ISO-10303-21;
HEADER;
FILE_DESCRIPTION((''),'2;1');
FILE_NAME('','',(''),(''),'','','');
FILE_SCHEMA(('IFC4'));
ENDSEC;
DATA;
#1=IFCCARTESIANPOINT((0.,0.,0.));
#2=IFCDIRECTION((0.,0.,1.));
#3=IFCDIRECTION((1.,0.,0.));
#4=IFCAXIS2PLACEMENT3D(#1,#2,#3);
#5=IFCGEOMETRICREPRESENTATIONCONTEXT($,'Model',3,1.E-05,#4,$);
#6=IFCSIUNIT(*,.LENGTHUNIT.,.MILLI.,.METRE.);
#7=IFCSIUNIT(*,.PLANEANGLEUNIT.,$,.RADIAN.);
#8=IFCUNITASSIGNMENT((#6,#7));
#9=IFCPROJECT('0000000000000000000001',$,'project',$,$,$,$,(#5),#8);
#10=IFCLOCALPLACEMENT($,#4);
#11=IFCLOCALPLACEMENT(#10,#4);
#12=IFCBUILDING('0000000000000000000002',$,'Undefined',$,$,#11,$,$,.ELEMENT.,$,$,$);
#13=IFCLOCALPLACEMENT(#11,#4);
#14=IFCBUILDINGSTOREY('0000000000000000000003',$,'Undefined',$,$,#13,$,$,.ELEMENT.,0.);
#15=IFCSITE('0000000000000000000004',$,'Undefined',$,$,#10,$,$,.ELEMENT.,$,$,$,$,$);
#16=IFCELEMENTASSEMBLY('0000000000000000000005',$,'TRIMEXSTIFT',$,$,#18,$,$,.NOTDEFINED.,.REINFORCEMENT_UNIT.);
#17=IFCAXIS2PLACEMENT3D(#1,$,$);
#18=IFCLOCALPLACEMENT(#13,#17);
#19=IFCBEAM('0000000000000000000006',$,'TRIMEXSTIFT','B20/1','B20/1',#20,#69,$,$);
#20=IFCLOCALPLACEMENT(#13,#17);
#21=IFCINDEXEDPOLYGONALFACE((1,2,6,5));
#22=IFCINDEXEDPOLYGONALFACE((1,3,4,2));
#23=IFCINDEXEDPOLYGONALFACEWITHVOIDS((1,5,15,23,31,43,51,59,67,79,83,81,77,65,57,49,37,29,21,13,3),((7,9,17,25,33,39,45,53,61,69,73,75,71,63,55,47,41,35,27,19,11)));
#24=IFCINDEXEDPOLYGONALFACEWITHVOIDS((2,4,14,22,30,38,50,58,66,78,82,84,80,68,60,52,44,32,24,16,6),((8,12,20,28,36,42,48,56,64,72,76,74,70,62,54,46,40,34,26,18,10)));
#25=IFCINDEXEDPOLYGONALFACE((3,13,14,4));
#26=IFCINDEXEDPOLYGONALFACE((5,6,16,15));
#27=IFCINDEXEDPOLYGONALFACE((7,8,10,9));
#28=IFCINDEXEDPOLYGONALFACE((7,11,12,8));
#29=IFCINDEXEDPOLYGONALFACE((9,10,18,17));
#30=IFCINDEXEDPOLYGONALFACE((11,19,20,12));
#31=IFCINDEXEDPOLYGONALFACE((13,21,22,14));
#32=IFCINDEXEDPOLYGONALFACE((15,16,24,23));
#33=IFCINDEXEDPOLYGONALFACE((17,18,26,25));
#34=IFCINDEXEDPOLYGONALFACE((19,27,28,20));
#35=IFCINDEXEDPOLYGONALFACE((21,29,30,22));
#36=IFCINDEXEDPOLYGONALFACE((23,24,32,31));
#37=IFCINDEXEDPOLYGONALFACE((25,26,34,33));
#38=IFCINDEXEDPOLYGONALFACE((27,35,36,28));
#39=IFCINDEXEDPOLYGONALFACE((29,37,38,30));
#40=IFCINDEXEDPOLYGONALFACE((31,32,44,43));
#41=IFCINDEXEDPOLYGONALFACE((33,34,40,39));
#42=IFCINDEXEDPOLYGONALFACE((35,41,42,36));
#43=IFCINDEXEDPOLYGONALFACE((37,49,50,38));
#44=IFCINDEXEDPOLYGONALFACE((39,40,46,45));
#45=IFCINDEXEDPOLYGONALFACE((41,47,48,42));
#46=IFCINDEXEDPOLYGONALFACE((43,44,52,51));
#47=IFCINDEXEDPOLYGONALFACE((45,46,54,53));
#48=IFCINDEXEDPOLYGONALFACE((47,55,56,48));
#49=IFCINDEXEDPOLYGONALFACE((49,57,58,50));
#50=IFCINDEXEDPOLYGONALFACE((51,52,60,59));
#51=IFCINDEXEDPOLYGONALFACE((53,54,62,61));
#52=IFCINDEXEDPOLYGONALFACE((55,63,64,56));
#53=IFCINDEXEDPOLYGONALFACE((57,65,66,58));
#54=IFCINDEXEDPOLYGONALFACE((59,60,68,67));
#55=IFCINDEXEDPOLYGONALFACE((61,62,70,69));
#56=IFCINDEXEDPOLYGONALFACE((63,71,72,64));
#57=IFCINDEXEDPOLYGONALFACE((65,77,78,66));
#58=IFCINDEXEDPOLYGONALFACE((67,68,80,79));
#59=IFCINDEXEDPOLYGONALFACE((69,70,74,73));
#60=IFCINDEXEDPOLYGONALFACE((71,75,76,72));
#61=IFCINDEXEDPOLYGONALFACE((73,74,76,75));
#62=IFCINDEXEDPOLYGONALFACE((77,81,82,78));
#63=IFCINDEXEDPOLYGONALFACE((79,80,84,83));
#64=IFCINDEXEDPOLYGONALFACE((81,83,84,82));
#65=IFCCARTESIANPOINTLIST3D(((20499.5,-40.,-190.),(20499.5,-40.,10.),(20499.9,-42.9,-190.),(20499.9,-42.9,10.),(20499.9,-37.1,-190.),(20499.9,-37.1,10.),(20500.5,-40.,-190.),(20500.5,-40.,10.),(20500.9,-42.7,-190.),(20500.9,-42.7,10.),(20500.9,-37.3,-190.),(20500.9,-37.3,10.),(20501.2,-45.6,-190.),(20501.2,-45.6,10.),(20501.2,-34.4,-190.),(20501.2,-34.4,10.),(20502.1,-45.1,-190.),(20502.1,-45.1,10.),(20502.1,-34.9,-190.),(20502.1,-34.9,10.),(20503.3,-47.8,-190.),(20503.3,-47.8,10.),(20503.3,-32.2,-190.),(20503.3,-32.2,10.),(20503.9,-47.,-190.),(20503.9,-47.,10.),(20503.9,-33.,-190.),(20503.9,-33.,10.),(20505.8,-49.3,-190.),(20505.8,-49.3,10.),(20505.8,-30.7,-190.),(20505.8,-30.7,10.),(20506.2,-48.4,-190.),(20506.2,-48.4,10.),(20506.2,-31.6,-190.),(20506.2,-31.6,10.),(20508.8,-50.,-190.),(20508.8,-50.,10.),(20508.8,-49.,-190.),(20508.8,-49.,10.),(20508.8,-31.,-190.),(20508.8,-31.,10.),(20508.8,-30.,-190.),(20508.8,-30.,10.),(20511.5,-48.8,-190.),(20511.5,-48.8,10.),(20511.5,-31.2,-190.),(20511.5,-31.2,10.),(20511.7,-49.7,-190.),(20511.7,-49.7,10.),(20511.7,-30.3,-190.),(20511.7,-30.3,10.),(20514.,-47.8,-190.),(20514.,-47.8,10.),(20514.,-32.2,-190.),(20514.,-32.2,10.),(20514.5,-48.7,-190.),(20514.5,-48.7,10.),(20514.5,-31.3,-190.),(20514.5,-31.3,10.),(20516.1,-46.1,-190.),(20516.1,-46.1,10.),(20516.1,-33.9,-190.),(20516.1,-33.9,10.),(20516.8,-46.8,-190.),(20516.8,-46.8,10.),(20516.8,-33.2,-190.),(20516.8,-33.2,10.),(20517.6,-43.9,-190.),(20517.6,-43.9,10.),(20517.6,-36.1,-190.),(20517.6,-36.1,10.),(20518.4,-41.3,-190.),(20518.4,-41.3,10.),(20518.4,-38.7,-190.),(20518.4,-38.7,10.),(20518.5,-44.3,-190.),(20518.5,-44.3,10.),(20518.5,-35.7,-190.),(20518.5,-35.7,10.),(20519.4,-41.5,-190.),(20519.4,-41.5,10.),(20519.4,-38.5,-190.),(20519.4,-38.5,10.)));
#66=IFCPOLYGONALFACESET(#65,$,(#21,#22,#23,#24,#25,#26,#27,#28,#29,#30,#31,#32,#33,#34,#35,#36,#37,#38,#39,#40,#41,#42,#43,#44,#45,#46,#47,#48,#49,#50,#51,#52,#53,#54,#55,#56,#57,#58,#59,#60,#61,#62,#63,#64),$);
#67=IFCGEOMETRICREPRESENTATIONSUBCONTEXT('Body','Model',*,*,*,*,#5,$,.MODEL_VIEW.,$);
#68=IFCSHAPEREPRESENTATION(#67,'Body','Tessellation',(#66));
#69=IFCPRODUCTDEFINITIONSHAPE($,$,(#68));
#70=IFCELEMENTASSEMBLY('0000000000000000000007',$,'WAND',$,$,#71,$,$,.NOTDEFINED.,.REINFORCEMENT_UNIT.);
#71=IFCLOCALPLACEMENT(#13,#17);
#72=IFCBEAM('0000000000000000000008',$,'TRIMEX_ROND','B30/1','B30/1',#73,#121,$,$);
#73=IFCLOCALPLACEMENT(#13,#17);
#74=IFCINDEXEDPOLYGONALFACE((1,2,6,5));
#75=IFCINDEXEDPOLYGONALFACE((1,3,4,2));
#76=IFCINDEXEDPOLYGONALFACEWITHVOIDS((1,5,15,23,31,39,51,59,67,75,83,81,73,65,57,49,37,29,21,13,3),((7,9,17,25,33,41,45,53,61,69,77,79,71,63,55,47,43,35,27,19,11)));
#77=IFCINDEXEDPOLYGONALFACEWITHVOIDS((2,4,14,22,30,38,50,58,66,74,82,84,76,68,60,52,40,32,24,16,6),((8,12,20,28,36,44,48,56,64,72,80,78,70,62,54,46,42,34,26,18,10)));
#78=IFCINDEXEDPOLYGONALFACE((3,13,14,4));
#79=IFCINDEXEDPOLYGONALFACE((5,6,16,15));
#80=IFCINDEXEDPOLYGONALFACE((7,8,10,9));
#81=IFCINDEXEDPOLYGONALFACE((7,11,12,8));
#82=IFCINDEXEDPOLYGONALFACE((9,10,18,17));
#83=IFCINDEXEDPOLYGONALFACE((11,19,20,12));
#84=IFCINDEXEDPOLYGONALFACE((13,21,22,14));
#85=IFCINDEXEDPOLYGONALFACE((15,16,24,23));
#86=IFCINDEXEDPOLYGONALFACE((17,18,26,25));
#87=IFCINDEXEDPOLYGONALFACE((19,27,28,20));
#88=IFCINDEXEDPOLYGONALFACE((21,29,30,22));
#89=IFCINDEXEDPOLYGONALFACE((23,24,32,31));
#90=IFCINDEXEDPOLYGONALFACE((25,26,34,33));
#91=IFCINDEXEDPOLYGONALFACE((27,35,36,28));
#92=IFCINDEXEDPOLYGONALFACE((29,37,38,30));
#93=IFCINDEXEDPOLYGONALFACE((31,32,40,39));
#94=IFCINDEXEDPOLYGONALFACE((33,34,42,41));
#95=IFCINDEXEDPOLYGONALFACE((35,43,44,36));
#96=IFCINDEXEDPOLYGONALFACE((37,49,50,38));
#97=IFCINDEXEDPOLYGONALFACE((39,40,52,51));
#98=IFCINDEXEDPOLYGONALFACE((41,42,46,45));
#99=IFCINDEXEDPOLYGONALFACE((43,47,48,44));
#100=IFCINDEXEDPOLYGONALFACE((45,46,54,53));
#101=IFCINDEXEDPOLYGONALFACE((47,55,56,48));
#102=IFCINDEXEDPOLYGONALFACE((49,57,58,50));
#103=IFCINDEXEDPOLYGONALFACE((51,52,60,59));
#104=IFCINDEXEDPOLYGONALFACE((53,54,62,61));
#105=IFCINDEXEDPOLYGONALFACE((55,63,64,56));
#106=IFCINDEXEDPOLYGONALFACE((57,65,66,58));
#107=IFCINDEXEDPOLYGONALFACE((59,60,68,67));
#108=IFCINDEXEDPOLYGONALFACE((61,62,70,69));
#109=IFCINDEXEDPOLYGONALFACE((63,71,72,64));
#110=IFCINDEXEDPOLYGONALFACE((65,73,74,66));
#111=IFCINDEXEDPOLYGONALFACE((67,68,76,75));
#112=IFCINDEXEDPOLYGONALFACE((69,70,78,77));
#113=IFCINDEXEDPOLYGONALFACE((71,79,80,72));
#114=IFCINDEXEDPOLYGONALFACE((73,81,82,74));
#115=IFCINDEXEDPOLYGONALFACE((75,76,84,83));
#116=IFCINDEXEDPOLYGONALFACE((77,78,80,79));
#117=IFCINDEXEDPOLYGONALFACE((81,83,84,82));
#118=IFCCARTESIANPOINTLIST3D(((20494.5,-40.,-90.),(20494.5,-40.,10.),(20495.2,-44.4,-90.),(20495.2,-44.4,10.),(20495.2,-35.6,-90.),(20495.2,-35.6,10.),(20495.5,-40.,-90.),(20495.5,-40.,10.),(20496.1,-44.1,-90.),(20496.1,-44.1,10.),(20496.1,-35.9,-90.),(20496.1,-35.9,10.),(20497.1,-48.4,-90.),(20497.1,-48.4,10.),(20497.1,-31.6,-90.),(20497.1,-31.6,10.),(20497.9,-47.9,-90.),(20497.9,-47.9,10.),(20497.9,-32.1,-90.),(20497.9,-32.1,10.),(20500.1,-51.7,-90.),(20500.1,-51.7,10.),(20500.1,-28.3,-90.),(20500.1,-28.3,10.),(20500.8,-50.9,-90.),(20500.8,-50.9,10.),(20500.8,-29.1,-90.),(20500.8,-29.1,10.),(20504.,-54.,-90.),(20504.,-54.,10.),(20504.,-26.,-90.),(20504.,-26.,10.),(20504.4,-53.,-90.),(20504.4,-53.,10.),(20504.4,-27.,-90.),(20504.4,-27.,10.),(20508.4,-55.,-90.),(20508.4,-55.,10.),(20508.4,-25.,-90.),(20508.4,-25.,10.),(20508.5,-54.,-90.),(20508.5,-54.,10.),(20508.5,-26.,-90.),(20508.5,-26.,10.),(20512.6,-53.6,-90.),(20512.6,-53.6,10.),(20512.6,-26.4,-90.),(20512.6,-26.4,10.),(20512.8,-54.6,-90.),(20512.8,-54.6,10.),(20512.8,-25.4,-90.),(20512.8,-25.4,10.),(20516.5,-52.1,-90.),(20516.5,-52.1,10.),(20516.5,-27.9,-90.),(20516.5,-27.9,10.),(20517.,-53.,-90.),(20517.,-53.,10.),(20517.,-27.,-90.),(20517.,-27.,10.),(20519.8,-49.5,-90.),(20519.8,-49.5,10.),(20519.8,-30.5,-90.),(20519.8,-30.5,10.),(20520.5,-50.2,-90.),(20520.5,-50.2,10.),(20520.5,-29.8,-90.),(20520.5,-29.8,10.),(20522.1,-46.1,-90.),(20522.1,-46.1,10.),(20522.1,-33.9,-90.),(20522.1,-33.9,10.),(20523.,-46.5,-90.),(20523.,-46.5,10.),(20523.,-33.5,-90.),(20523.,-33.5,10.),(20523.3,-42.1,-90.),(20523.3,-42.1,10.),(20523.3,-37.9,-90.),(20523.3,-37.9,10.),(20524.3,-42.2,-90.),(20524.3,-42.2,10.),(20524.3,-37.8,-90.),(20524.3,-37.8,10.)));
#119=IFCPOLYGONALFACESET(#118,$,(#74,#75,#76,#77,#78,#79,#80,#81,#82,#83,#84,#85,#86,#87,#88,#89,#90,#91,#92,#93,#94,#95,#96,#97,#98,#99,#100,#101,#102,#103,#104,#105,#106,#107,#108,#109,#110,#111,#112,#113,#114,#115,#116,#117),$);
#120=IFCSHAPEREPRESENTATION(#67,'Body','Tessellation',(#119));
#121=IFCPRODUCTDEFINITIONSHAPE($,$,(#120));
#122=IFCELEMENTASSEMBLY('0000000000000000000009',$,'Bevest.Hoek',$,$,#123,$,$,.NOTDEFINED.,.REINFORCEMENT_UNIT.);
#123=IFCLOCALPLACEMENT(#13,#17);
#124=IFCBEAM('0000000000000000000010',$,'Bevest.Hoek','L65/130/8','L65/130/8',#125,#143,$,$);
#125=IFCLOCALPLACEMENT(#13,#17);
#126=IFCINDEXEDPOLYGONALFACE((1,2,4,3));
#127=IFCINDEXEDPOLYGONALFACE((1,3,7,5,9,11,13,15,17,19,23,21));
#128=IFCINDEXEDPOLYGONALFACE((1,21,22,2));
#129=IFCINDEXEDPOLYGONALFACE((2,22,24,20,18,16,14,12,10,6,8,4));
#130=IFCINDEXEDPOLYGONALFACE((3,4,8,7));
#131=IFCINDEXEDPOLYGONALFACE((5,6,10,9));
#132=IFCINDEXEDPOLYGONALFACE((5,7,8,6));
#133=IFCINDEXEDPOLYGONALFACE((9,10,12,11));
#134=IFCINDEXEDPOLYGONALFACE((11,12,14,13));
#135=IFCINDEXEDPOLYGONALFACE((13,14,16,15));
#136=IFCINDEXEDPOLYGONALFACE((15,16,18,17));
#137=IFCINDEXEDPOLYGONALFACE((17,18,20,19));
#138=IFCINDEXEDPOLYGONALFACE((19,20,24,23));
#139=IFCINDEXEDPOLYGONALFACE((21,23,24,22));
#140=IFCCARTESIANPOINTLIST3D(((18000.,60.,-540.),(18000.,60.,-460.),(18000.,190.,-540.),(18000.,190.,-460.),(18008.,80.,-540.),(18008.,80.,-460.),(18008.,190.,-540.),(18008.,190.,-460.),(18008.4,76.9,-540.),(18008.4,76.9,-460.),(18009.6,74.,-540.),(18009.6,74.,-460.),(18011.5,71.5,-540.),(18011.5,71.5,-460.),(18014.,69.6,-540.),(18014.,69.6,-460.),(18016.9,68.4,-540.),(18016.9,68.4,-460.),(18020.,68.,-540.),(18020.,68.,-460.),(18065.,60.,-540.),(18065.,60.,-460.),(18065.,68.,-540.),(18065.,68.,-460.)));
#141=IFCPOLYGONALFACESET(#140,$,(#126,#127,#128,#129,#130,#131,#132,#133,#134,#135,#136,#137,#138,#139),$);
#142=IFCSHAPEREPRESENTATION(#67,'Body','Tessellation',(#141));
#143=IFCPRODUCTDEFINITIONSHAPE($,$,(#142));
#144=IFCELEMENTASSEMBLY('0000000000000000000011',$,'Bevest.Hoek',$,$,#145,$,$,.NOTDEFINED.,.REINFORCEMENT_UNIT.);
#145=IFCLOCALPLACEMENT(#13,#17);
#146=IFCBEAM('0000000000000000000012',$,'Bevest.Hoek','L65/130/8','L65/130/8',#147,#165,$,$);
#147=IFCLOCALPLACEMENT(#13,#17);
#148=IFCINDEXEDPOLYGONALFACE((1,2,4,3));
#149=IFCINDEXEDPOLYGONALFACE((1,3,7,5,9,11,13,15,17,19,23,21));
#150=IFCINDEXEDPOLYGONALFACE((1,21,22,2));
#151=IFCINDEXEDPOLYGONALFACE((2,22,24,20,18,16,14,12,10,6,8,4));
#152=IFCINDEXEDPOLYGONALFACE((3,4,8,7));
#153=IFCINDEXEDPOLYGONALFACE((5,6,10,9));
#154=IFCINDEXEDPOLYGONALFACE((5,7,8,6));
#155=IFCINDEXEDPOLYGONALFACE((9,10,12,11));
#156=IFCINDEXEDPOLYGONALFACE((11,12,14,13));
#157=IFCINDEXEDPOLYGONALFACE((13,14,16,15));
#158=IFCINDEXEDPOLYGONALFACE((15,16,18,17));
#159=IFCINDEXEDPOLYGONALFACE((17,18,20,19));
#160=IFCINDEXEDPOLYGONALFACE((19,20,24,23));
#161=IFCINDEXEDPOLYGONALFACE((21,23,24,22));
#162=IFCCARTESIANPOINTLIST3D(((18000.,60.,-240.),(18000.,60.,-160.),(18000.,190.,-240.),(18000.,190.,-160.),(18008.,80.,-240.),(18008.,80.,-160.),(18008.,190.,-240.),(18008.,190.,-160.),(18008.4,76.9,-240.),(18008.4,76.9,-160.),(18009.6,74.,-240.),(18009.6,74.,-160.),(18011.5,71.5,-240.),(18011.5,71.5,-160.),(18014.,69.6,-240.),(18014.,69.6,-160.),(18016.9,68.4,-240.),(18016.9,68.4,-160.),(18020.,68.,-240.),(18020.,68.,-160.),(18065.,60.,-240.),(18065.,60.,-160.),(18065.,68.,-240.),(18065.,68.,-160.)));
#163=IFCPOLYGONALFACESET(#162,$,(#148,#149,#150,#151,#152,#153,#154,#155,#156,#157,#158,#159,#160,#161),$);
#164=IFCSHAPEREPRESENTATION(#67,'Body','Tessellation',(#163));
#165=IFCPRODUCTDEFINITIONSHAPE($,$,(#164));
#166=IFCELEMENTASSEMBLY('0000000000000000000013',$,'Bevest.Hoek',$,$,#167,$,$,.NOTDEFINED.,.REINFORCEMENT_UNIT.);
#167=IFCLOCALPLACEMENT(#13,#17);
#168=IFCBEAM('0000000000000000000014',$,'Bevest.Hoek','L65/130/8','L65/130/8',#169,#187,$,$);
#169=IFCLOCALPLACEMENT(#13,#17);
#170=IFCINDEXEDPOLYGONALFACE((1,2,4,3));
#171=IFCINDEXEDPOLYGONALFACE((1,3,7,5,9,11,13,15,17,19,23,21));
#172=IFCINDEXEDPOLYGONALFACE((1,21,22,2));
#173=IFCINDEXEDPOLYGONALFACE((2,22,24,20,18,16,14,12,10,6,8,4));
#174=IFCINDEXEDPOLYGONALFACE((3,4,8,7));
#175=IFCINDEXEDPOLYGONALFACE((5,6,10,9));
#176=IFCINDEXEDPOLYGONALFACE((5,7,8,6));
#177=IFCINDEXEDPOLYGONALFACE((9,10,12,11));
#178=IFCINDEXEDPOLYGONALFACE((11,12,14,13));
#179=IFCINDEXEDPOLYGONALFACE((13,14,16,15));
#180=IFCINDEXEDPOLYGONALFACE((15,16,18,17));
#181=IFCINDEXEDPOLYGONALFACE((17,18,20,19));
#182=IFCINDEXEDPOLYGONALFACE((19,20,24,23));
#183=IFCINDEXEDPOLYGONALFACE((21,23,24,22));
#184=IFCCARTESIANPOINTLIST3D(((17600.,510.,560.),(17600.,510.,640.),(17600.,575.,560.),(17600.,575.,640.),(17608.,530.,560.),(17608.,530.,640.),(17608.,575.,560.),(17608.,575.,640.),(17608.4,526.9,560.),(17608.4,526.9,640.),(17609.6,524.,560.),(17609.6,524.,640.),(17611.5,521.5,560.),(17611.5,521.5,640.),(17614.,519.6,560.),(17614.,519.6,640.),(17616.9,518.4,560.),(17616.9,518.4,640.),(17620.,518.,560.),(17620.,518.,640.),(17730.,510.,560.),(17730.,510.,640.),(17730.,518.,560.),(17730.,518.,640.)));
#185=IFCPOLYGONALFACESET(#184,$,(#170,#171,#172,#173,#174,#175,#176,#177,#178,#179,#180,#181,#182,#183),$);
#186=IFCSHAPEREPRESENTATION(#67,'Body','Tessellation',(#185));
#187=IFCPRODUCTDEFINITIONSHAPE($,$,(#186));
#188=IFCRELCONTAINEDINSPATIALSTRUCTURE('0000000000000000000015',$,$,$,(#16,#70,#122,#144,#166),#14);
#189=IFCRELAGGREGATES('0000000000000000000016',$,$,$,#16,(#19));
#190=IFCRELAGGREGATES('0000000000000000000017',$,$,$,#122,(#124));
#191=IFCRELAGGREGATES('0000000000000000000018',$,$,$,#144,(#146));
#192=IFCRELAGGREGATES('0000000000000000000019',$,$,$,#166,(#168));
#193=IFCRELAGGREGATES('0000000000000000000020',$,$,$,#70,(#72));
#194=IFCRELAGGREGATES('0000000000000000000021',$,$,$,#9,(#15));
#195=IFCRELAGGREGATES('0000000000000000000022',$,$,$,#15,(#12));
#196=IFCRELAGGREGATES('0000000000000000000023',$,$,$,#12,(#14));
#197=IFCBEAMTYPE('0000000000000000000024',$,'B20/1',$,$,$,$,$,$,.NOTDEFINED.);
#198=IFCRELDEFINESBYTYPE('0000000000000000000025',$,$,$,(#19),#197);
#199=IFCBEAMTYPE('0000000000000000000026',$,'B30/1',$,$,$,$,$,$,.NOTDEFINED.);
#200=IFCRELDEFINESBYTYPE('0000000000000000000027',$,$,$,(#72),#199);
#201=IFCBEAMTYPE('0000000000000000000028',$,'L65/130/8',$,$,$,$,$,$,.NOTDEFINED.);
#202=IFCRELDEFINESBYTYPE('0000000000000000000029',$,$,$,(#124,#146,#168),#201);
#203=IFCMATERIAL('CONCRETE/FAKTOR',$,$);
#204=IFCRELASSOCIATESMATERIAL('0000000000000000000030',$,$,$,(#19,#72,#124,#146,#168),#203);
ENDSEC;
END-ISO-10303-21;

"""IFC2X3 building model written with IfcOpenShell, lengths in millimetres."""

from ifc_helpers import new_model, si_unit, frame, frame_2d, origin_with_axes, place, context, subcontext, project, spatial, hollow_circle, l_section, extrude, material, type_object, element, aggregate, save


model = new_model("IFC2X3")

# Units and contexts
model_context = context("Model", 3, precision=1e-05, world=origin_with_axes())
body_context = subcontext(model_context, "Body", "Model", "MODEL_VIEW")
ifc_project = project(units=[si_unit("LENGTHUNIT", "METRE", prefix="MILLI"), si_unit("PLANEANGLEUNIT", "RADIAN")], contexts=[model_context])

# Site, building, storey
site_placement = place(None, origin_with_axes())
site = spatial("IfcSite", under=ifc_project, at=site_placement, Name="Undefined", CompositionType="ELEMENT")
building_placement = place(site_placement, origin_with_axes())
building = spatial("IfcBuilding", under=site, at=building_placement, Name="Undefined", CompositionType="ELEMENT")
storey_placement = place(building_placement, origin_with_axes())
storey = spatial("IfcBuildingStorey", under=building, at=storey_placement, Name="Undefined", CompositionType="ELEMENT", Elevation=0.0)

# Element assemblies, beams
assembly_1_placement = place(storey_placement, origin_with_axes())
assembly_1 = element("IfcElementAssembly", 1, at=assembly_1_placement, inside=storey, Name="TRIMEXSTIFT", AssemblyPlace="NOTDEFINED", PredefinedType="REINFORCEMENT_UNIT")
ifc_material_1 = material(Name="CONCRETE/FAKTOR")
beam_type_1 = type_object("IfcBeamType", Name="B20/1", PredefinedType="NOTDEFINED")
beam_1_placement = place(assembly_1_placement, frame((20509.5, -40.0, -190.0), z_axis=(0.0, 1.0, 0.0), x_axis=(0.0, 0.0, 1.0)))
beam_1 = element("IfcBeam", 2, at=beam_1_placement, type_object=beam_type_1, material=ifc_material_1, Name="TRIMEXSTIFT", Description="B20/1", ObjectType="B20/1", context=body_context, shape_type="SweptSolid", body=[
    extrude(hollow_circle(Radius=10.0, WallThickness=1.0, at=frame_2d((0.0, 0.0), x_axis=(1.0, 0.0))), frame((200.0, 0.0, 0.0), z_axis=(-1.0, 0.0, 0.0), x_axis=(0.0, -1.0, 0.0)), (0.0, 0.0, 1.0), 200.0),
])
aggregate(assembly_1, [beam_1])
assembly_2_placement = place(storey_placement, origin_with_axes())
assembly_2 = element("IfcElementAssembly", 3, at=assembly_2_placement, inside=storey, Name="WAND", AssemblyPlace="NOTDEFINED", PredefinedType="REINFORCEMENT_UNIT")
beam_type_2 = type_object("IfcBeamType", Name="B30/1", PredefinedType="NOTDEFINED")
beam_2_placement = place(assembly_2_placement, frame((20509.5, -40.0, -90.0), z_axis=(0.0, 1.0, 0.0), x_axis=(0.0, 0.0, 1.0)))
beam_2 = element("IfcBeam", 4, at=beam_2_placement, type_object=beam_type_2, material=ifc_material_1, Name="TRIMEX_ROND", Description="B30/1", ObjectType="B30/1", context=body_context, shape_type="SweptSolid", body=[
    extrude(hollow_circle(Radius=15.0, WallThickness=1.0, at=frame_2d((0.0, 0.0), x_axis=(1.0, 0.0))), frame((100.0, 0.0, 0.0), z_axis=(-1.0, 0.0, 0.0), x_axis=(0.0, -1.0, 0.0)), (0.0, 0.0, 1.0), 100.0),
])
assembly_3_placement = place(storey_placement, origin_with_axes())
assembly_3 = element("IfcElementAssembly", 5, at=assembly_3_placement, inside=storey, Name="Bevest.Hoek", AssemblyPlace="NOTDEFINED", PredefinedType="REINFORCEMENT_UNIT")
beam_type_3 = type_object("IfcBeamType", Name="L65/130/8", PredefinedType="NOTDEFINED")
beam_3_placement = place(assembly_3_placement, frame((18032.5, 125.0, -540.0), z_axis=(1.0, 0.0, 0.0), x_axis=(0.0, 0.0, 1.0)))
beam_3 = element("IfcBeam", 6, at=beam_3_placement, type_object=beam_type_3, material=ifc_material_1, Name="Bevest.Hoek", Description="L65/130/8", ObjectType="L65/130/8", context=body_context, shape_type="SweptSolid", body=[
    extrude(l_section(Depth=65.0, Width=130.0, Thickness=8.0, FilletRadius=12.0, at=frame_2d((0.0, 0.0), x_axis=(1.0, 0.0))), frame((80.0, 0.0, 0.0), z_axis=(-1.0, 0.0, 0.0), x_axis=(0.0, -1.0, 0.0)), (0.0, 0.0, 1.0), 80.0),
])
aggregate(assembly_3, [beam_3])
assembly_4_placement = place(storey_placement, origin_with_axes())
assembly_4 = element("IfcElementAssembly", 7, at=assembly_4_placement, inside=storey, Name="Bevest.Hoek", AssemblyPlace="NOTDEFINED", PredefinedType="REINFORCEMENT_UNIT")
beam_4_placement = place(assembly_4_placement, frame((18032.5, 125.0, -240.0), z_axis=(1.0, 0.0, 0.0), x_axis=(0.0, 0.0, 1.0)))
beam_4 = element("IfcBeam", 8, at=beam_4_placement, type_object=beam_type_3, material=ifc_material_1, Name="Bevest.Hoek", Description="L65/130/8", ObjectType="L65/130/8", context=body_context, shape_type="SweptSolid", body=[
    extrude(l_section(Depth=65.0, Width=130.0, Thickness=8.0, FilletRadius=12.0, at=frame_2d((0.0, 0.0), x_axis=(1.0, 0.0))), frame((80.0, 0.0, 0.0), z_axis=(-1.0, 0.0, 0.0), x_axis=(0.0, -1.0, 0.0)), (0.0, 0.0, 1.0), 80.0),
])
aggregate(assembly_4, [beam_4])
assembly_5_placement = place(storey_placement, origin_with_axes())
assembly_5 = element("IfcElementAssembly", 9, at=assembly_5_placement, inside=storey, Name="Bevest.Hoek", AssemblyPlace="NOTDEFINED", PredefinedType="REINFORCEMENT_UNIT")
beam_5_placement = place(assembly_5_placement, frame((17665.0, 542.5, 640.0), z_axis=(0.0, 1.0, 0.0), x_axis=(0.0, 0.0, -1.0)))
beam_5 = element("IfcBeam", 10, at=beam_5_placement, type_object=beam_type_3, material=ifc_material_1, Name="Bevest.Hoek", Description="L65/130/8", ObjectType="L65/130/8", context=body_context, shape_type="SweptSolid", body=[
    extrude(l_section(Depth=65.0, Width=130.0, Thickness=8.0, FilletRadius=12.0, at=frame_2d((0.0, 0.0), x_axis=(1.0, 0.0))), frame((80.0, 0.0, 0.0), z_axis=(-1.0, 0.0, 0.0), x_axis=(0.0, -1.0, 0.0)), (0.0, 0.0, 1.0), 80.0),
])
aggregate(assembly_5, [beam_5])

aggregate(assembly_2, [beam_2])

save(model, "model.ifc")
